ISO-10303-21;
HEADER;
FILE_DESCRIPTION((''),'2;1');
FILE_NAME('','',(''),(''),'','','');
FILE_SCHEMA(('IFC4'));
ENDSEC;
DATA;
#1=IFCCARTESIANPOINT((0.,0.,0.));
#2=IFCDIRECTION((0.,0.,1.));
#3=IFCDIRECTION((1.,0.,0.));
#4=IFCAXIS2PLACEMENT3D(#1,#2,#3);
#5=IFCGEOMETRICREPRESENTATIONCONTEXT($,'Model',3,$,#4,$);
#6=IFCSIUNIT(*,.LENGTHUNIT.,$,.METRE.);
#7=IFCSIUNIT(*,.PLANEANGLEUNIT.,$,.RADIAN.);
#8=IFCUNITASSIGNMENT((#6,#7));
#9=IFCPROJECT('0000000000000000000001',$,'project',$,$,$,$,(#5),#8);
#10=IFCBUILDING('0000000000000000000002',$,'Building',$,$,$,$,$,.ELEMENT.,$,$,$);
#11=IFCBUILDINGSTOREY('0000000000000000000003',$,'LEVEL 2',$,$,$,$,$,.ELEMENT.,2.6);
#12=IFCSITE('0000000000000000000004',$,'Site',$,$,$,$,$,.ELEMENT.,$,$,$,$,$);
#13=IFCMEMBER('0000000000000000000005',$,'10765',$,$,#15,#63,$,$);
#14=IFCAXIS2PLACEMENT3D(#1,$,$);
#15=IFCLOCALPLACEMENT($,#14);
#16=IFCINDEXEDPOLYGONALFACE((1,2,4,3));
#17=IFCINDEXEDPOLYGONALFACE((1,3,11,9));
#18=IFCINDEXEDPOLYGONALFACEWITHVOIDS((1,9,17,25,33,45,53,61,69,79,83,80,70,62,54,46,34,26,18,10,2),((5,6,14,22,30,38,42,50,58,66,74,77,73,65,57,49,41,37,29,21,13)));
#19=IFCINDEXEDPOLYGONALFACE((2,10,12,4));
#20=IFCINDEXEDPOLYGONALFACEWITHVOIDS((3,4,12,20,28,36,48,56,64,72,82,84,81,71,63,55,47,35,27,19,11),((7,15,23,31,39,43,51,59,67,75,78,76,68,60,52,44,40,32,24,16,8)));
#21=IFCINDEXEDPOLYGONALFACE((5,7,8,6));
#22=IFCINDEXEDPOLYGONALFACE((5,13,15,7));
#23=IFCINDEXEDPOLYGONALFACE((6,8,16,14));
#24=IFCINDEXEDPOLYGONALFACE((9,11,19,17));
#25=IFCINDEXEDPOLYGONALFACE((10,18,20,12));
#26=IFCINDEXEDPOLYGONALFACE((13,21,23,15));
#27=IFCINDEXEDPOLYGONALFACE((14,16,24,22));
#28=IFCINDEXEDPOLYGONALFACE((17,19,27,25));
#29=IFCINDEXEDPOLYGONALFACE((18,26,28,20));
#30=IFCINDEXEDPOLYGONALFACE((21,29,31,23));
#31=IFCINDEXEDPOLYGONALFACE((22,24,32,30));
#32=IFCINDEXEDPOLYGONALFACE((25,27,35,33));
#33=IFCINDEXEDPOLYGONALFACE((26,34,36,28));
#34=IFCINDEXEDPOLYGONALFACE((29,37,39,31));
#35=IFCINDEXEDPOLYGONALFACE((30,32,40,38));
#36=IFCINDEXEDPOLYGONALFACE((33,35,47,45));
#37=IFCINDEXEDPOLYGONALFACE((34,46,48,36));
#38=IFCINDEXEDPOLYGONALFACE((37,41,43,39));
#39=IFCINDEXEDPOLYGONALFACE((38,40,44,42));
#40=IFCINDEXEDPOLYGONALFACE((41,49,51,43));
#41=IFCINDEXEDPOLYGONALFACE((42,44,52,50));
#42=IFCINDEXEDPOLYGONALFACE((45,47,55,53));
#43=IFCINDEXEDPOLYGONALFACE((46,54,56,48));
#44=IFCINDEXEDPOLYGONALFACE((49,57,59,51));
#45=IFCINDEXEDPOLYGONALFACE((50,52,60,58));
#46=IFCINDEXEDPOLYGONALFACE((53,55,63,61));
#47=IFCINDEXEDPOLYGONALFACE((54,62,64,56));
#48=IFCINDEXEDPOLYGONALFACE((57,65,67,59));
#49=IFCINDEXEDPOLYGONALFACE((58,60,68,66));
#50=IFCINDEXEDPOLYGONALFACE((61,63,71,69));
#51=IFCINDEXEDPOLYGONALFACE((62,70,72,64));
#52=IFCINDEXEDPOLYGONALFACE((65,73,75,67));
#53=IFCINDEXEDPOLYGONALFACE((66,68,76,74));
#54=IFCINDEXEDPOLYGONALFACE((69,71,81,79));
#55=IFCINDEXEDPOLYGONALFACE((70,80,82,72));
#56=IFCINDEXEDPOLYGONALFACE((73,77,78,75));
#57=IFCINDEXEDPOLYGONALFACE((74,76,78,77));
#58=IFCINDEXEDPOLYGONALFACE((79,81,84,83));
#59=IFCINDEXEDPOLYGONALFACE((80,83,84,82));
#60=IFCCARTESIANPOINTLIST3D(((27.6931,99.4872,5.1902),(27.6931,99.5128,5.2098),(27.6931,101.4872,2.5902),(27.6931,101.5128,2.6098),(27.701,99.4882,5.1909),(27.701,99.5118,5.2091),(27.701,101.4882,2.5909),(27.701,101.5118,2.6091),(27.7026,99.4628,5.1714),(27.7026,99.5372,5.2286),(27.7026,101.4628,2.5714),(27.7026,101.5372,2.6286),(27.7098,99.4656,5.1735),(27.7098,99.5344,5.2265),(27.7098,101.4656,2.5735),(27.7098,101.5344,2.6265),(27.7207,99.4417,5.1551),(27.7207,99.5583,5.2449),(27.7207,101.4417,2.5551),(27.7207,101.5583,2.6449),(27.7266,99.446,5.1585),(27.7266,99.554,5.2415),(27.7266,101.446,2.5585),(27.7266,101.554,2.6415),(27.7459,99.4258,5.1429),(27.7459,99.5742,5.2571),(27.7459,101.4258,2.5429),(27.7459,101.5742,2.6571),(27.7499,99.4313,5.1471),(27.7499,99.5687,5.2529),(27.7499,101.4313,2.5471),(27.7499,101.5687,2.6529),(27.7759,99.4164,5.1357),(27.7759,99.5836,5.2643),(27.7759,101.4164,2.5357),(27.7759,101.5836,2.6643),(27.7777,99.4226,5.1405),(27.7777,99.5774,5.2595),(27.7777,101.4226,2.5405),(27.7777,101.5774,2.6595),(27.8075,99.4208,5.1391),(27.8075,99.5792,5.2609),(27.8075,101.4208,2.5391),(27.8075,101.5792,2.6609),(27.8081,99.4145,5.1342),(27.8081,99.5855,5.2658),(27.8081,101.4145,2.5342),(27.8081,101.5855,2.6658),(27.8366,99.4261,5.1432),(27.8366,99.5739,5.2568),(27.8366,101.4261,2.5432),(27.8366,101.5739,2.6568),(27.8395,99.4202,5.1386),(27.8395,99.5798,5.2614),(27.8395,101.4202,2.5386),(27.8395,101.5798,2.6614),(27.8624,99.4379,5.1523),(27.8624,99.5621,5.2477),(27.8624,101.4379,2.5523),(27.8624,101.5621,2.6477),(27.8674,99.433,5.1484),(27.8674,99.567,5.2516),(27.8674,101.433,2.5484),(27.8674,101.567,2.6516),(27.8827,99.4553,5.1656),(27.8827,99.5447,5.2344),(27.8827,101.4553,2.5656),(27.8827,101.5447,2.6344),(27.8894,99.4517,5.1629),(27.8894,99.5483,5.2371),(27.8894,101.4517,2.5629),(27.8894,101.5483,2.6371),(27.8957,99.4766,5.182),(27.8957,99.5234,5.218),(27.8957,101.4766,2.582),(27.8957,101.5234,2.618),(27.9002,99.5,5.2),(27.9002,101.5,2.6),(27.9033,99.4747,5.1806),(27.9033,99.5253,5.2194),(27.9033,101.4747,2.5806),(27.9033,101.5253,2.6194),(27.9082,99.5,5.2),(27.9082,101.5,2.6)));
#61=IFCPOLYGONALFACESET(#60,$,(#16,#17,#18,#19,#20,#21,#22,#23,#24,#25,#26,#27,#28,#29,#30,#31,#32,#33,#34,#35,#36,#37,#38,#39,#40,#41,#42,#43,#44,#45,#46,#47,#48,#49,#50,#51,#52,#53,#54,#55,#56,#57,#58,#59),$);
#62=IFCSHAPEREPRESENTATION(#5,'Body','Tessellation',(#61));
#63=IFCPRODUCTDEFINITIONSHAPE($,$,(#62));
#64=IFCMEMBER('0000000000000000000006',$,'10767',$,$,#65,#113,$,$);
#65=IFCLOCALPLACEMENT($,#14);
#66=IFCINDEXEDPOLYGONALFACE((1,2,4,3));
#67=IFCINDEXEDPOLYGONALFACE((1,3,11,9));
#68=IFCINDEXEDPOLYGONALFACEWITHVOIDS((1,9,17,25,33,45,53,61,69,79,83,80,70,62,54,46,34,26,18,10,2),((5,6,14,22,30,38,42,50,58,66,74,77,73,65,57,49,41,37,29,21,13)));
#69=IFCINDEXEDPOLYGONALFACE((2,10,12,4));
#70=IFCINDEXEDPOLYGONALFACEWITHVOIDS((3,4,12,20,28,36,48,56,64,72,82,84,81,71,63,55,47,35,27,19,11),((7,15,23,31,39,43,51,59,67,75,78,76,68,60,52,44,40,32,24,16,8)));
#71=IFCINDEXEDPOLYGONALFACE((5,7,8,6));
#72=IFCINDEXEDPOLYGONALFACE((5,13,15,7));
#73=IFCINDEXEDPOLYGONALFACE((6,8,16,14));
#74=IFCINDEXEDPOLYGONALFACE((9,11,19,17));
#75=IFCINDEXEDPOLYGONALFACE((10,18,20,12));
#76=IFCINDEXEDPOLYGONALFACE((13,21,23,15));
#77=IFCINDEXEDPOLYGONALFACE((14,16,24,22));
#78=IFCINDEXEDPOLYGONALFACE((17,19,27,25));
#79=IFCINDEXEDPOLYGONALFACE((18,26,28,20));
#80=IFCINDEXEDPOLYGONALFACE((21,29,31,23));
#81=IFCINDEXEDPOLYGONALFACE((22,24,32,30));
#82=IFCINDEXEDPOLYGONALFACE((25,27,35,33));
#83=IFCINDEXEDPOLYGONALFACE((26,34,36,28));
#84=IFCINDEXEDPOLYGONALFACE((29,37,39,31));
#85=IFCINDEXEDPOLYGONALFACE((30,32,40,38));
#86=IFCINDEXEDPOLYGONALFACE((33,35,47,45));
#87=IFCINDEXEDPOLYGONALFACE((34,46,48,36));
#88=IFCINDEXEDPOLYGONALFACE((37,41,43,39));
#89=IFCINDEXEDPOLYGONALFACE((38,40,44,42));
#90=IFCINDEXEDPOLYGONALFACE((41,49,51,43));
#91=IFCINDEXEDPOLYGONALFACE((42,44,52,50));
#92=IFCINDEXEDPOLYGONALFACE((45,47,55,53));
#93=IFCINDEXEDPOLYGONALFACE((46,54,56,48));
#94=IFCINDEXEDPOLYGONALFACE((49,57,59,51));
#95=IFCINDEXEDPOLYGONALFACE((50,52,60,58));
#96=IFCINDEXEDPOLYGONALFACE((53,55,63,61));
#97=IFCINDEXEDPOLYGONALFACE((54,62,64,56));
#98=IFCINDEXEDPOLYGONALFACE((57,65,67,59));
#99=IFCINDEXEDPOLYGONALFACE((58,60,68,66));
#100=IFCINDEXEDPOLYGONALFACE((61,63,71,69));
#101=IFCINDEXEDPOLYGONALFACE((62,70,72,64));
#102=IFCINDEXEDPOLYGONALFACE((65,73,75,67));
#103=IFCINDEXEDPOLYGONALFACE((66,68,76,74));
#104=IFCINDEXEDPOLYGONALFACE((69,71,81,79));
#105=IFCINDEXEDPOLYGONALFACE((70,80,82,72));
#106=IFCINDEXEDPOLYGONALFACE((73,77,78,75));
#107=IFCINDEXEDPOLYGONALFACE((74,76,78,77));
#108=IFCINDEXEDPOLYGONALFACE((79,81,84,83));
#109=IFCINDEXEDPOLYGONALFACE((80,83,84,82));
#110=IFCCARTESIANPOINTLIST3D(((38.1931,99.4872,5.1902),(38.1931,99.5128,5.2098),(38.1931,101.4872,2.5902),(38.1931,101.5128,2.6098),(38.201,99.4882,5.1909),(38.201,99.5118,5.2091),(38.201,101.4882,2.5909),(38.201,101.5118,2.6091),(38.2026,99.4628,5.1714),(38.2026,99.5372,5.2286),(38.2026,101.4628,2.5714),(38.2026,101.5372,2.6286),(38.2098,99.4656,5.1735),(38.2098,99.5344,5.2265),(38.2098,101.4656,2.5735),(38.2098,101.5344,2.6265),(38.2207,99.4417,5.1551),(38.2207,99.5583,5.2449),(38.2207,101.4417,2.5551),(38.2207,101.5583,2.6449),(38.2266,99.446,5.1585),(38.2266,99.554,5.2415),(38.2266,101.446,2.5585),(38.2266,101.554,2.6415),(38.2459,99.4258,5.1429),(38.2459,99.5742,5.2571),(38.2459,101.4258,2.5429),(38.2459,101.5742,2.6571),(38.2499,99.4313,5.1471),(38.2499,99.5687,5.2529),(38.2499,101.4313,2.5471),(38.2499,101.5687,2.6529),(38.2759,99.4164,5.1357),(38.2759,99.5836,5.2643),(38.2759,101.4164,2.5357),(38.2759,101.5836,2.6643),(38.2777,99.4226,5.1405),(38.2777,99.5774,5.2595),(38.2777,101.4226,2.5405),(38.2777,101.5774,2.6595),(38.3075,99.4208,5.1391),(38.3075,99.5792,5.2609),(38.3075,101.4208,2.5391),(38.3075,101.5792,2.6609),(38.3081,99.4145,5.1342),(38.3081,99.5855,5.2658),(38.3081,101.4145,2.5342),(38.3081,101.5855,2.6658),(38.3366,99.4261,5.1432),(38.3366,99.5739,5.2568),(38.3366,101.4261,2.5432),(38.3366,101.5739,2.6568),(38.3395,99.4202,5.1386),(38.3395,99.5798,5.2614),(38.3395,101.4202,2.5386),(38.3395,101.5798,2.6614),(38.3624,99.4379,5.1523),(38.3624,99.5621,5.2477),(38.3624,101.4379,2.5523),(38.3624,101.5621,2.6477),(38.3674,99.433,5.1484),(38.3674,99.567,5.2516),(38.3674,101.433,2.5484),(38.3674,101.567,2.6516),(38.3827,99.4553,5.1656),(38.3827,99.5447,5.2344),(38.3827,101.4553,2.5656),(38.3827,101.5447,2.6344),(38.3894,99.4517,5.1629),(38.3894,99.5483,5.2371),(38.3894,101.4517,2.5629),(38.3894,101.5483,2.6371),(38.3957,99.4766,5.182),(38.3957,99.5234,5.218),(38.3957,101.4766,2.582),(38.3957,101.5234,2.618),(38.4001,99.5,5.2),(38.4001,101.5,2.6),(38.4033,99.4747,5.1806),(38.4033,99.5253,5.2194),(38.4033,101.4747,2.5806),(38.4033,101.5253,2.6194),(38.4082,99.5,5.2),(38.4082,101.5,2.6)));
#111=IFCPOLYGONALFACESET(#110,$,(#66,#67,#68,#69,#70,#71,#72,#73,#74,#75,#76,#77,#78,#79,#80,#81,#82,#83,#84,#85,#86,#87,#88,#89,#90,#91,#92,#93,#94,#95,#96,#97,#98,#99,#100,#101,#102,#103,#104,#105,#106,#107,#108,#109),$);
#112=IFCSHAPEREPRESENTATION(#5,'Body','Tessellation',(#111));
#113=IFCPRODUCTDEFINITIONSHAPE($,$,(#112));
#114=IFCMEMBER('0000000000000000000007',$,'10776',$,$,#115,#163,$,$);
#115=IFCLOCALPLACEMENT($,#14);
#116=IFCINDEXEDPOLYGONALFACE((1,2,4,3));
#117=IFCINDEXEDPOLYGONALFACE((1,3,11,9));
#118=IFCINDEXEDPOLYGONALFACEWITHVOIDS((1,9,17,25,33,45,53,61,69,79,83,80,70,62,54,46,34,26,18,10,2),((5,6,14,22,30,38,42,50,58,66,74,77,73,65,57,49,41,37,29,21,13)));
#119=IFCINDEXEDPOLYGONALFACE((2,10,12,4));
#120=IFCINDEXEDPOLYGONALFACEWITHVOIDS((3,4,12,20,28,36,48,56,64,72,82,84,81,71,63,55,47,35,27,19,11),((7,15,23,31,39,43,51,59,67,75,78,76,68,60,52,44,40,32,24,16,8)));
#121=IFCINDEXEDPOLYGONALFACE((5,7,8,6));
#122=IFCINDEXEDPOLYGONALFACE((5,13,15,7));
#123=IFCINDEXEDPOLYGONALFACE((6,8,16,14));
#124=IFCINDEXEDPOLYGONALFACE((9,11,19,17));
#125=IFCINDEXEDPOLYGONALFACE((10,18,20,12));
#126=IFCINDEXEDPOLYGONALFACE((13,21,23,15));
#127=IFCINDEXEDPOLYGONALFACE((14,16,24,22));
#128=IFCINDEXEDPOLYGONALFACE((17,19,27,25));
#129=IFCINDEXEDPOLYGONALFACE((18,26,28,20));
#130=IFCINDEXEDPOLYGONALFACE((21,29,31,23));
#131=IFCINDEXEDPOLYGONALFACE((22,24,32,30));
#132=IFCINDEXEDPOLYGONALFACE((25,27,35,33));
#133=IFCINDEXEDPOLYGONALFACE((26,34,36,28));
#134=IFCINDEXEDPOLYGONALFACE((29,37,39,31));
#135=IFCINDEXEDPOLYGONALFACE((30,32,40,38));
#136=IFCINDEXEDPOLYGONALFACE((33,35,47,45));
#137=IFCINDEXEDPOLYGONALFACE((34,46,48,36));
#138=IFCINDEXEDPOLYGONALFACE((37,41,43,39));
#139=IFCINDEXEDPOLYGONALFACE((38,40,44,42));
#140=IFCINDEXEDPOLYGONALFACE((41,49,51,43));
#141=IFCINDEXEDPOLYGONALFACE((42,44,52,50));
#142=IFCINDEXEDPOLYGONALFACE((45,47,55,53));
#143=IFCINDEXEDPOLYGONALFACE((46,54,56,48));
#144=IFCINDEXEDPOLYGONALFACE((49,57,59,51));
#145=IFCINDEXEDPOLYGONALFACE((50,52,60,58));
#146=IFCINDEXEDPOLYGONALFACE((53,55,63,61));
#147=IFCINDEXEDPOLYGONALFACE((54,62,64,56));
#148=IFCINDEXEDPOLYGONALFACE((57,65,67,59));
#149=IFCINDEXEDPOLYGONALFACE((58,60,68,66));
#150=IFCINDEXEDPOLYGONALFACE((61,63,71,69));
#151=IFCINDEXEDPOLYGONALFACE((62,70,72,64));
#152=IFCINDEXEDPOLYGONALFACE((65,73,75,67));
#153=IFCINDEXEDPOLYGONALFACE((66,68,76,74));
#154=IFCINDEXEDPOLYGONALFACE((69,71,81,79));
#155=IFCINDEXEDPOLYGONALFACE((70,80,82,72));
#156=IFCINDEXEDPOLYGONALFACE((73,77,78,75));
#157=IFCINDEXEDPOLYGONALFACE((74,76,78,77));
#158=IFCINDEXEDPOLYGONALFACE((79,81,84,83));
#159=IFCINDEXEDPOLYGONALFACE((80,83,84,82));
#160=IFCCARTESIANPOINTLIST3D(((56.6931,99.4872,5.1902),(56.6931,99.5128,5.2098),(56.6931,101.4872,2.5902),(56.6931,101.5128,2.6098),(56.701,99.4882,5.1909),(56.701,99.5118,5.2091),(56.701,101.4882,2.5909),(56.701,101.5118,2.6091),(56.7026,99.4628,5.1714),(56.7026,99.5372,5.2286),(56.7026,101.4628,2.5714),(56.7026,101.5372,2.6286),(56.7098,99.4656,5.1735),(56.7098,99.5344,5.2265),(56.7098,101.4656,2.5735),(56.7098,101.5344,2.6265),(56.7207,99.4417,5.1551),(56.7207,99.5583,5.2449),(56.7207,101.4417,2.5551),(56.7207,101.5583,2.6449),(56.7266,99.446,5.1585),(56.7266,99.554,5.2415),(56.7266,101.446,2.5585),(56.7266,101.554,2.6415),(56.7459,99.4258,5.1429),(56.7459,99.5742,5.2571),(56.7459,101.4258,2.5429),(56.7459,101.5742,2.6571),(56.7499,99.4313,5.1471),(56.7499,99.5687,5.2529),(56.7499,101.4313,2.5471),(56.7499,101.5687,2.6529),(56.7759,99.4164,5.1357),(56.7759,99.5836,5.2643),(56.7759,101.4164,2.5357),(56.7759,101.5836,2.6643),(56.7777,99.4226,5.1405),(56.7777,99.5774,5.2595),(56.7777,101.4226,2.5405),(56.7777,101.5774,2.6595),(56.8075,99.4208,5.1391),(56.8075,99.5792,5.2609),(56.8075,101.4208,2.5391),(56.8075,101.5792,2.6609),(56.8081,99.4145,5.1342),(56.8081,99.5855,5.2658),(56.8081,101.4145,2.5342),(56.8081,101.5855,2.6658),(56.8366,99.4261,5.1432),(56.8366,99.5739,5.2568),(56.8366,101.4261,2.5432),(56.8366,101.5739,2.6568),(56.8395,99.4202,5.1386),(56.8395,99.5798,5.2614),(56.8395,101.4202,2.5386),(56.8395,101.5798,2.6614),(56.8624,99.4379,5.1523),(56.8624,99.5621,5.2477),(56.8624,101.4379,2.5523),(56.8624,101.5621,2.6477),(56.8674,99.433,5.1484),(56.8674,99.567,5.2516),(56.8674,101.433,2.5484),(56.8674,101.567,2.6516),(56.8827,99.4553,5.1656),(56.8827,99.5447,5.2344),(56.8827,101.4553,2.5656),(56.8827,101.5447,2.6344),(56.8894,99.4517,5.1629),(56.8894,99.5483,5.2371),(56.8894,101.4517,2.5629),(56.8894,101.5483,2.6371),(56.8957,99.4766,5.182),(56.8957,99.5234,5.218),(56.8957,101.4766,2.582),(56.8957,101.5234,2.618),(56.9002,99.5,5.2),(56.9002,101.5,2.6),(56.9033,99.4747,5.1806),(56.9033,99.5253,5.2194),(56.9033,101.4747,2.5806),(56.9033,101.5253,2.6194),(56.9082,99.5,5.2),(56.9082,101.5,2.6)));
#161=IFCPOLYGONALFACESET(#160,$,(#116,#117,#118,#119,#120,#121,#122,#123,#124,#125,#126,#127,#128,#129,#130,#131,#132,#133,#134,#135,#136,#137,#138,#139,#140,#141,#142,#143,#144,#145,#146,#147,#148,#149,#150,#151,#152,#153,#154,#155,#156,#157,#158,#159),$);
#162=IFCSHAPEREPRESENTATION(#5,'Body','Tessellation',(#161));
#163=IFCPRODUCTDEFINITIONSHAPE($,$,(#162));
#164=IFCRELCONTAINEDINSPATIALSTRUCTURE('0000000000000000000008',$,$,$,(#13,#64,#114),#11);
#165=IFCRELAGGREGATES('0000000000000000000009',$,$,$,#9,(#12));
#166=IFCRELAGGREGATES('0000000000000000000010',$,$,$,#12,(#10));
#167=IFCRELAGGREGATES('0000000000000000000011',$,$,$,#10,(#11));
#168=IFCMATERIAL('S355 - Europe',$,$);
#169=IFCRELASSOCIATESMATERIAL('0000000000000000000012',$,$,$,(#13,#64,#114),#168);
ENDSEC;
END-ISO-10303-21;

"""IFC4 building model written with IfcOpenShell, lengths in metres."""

from ifc_helpers import new_model, si_unit, frame, origin_with_axes, origin_2d_with_axis, place, context, project, spatial, hollow_circle, extrude, material, material_profile, profile_set, profile_usage, element, save


model = new_model("IFC4")

# Units and contexts
model_context = context("Model", 3, world=origin_with_axes())
ifc_project = project(units=[si_unit("LENGTHUNIT", "METRE"), si_unit("PLANEANGLEUNIT", "RADIAN")], contexts=[model_context])

# Site, building, storey
site = spatial("IfcSite", under=ifc_project, Name="Site", CompositionType="ELEMENT")
building = spatial("IfcBuilding", under=site, Name="Building", CompositionType="ELEMENT")
storey = spatial("IfcBuildingStorey", under=building, Name="LEVEL 2", CompositionType="ELEMENT", Elevation=2.6)

# Shared definitions
ifc_material = material(Name="S355 - Europe")

# Members
ifc_material_profile_1 = material_profile(ifc_material, hollow_circle(Radius=0.1081, WallThickness=0.008, at=origin_2d_with_axis()))
ifc_profile_set_1 = profile_set([ifc_material_profile_1])
ifc_profile_usage_1 = profile_usage(ifc_profile_set_1, cardinal=10)
member_1_placement = place(None, frame((27.8, 101.5, 2.6), z_axis=(0.0, -0.609711, 0.792624), x_axis=(1.0, 0.0, 0.0)))
element("IfcMember", 1, at=member_1_placement, inside=storey, material=ifc_profile_usage_1, Name="10765", context=model_context, shape_type="SweptSolid", body=[
    extrude(hollow_circle(Radius=0.1081, WallThickness=0.008, at=origin_2d_with_axis()), origin_with_axes(), (0.0, 0.0, 1.0), 3.2802),
])
ifc_material_profile_2 = material_profile(ifc_material, hollow_circle(Radius=0.1081, WallThickness=0.008, at=origin_2d_with_axis()))
ifc_profile_set_2 = profile_set([ifc_material_profile_2])
ifc_profile_usage_2 = profile_usage(ifc_profile_set_2, cardinal=10)
member_2_placement = place(None, frame((38.3, 101.5, 2.6), z_axis=(0.0, -0.609711, 0.792624), x_axis=(1.0, 0.0, 0.0)))
element("IfcMember", 2, at=member_2_placement, inside=storey, material=ifc_profile_usage_2, Name="10767", context=model_context, shape_type="SweptSolid", body=[
    extrude(hollow_circle(Radius=0.1081, WallThickness=0.008, at=origin_2d_with_axis()), origin_with_axes(), (0.0, 0.0, 1.0), 3.2802),
])
ifc_material_profile_3 = material_profile(ifc_material, hollow_circle(Radius=0.1081, WallThickness=0.008, at=origin_2d_with_axis()))
ifc_profile_set_3 = profile_set([ifc_material_profile_3])
ifc_profile_usage_3 = profile_usage(ifc_profile_set_3, cardinal=10)
member_3_placement = place(None, frame((56.8, 101.5, 2.6), z_axis=(0.0, -0.609711, 0.792624), x_axis=(1.0, 0.0, 0.0)))
element("IfcMember", 3, at=member_3_placement, inside=storey, material=ifc_profile_usage_3, Name="10776", context=model_context, shape_type="SweptSolid", body=[
    extrude(hollow_circle(Radius=0.1081, WallThickness=0.008, at=origin_2d_with_axis()), origin_with_axes(), (0.0, 0.0, 1.0), 3.2802),
])

save(model, "model.ifc")
